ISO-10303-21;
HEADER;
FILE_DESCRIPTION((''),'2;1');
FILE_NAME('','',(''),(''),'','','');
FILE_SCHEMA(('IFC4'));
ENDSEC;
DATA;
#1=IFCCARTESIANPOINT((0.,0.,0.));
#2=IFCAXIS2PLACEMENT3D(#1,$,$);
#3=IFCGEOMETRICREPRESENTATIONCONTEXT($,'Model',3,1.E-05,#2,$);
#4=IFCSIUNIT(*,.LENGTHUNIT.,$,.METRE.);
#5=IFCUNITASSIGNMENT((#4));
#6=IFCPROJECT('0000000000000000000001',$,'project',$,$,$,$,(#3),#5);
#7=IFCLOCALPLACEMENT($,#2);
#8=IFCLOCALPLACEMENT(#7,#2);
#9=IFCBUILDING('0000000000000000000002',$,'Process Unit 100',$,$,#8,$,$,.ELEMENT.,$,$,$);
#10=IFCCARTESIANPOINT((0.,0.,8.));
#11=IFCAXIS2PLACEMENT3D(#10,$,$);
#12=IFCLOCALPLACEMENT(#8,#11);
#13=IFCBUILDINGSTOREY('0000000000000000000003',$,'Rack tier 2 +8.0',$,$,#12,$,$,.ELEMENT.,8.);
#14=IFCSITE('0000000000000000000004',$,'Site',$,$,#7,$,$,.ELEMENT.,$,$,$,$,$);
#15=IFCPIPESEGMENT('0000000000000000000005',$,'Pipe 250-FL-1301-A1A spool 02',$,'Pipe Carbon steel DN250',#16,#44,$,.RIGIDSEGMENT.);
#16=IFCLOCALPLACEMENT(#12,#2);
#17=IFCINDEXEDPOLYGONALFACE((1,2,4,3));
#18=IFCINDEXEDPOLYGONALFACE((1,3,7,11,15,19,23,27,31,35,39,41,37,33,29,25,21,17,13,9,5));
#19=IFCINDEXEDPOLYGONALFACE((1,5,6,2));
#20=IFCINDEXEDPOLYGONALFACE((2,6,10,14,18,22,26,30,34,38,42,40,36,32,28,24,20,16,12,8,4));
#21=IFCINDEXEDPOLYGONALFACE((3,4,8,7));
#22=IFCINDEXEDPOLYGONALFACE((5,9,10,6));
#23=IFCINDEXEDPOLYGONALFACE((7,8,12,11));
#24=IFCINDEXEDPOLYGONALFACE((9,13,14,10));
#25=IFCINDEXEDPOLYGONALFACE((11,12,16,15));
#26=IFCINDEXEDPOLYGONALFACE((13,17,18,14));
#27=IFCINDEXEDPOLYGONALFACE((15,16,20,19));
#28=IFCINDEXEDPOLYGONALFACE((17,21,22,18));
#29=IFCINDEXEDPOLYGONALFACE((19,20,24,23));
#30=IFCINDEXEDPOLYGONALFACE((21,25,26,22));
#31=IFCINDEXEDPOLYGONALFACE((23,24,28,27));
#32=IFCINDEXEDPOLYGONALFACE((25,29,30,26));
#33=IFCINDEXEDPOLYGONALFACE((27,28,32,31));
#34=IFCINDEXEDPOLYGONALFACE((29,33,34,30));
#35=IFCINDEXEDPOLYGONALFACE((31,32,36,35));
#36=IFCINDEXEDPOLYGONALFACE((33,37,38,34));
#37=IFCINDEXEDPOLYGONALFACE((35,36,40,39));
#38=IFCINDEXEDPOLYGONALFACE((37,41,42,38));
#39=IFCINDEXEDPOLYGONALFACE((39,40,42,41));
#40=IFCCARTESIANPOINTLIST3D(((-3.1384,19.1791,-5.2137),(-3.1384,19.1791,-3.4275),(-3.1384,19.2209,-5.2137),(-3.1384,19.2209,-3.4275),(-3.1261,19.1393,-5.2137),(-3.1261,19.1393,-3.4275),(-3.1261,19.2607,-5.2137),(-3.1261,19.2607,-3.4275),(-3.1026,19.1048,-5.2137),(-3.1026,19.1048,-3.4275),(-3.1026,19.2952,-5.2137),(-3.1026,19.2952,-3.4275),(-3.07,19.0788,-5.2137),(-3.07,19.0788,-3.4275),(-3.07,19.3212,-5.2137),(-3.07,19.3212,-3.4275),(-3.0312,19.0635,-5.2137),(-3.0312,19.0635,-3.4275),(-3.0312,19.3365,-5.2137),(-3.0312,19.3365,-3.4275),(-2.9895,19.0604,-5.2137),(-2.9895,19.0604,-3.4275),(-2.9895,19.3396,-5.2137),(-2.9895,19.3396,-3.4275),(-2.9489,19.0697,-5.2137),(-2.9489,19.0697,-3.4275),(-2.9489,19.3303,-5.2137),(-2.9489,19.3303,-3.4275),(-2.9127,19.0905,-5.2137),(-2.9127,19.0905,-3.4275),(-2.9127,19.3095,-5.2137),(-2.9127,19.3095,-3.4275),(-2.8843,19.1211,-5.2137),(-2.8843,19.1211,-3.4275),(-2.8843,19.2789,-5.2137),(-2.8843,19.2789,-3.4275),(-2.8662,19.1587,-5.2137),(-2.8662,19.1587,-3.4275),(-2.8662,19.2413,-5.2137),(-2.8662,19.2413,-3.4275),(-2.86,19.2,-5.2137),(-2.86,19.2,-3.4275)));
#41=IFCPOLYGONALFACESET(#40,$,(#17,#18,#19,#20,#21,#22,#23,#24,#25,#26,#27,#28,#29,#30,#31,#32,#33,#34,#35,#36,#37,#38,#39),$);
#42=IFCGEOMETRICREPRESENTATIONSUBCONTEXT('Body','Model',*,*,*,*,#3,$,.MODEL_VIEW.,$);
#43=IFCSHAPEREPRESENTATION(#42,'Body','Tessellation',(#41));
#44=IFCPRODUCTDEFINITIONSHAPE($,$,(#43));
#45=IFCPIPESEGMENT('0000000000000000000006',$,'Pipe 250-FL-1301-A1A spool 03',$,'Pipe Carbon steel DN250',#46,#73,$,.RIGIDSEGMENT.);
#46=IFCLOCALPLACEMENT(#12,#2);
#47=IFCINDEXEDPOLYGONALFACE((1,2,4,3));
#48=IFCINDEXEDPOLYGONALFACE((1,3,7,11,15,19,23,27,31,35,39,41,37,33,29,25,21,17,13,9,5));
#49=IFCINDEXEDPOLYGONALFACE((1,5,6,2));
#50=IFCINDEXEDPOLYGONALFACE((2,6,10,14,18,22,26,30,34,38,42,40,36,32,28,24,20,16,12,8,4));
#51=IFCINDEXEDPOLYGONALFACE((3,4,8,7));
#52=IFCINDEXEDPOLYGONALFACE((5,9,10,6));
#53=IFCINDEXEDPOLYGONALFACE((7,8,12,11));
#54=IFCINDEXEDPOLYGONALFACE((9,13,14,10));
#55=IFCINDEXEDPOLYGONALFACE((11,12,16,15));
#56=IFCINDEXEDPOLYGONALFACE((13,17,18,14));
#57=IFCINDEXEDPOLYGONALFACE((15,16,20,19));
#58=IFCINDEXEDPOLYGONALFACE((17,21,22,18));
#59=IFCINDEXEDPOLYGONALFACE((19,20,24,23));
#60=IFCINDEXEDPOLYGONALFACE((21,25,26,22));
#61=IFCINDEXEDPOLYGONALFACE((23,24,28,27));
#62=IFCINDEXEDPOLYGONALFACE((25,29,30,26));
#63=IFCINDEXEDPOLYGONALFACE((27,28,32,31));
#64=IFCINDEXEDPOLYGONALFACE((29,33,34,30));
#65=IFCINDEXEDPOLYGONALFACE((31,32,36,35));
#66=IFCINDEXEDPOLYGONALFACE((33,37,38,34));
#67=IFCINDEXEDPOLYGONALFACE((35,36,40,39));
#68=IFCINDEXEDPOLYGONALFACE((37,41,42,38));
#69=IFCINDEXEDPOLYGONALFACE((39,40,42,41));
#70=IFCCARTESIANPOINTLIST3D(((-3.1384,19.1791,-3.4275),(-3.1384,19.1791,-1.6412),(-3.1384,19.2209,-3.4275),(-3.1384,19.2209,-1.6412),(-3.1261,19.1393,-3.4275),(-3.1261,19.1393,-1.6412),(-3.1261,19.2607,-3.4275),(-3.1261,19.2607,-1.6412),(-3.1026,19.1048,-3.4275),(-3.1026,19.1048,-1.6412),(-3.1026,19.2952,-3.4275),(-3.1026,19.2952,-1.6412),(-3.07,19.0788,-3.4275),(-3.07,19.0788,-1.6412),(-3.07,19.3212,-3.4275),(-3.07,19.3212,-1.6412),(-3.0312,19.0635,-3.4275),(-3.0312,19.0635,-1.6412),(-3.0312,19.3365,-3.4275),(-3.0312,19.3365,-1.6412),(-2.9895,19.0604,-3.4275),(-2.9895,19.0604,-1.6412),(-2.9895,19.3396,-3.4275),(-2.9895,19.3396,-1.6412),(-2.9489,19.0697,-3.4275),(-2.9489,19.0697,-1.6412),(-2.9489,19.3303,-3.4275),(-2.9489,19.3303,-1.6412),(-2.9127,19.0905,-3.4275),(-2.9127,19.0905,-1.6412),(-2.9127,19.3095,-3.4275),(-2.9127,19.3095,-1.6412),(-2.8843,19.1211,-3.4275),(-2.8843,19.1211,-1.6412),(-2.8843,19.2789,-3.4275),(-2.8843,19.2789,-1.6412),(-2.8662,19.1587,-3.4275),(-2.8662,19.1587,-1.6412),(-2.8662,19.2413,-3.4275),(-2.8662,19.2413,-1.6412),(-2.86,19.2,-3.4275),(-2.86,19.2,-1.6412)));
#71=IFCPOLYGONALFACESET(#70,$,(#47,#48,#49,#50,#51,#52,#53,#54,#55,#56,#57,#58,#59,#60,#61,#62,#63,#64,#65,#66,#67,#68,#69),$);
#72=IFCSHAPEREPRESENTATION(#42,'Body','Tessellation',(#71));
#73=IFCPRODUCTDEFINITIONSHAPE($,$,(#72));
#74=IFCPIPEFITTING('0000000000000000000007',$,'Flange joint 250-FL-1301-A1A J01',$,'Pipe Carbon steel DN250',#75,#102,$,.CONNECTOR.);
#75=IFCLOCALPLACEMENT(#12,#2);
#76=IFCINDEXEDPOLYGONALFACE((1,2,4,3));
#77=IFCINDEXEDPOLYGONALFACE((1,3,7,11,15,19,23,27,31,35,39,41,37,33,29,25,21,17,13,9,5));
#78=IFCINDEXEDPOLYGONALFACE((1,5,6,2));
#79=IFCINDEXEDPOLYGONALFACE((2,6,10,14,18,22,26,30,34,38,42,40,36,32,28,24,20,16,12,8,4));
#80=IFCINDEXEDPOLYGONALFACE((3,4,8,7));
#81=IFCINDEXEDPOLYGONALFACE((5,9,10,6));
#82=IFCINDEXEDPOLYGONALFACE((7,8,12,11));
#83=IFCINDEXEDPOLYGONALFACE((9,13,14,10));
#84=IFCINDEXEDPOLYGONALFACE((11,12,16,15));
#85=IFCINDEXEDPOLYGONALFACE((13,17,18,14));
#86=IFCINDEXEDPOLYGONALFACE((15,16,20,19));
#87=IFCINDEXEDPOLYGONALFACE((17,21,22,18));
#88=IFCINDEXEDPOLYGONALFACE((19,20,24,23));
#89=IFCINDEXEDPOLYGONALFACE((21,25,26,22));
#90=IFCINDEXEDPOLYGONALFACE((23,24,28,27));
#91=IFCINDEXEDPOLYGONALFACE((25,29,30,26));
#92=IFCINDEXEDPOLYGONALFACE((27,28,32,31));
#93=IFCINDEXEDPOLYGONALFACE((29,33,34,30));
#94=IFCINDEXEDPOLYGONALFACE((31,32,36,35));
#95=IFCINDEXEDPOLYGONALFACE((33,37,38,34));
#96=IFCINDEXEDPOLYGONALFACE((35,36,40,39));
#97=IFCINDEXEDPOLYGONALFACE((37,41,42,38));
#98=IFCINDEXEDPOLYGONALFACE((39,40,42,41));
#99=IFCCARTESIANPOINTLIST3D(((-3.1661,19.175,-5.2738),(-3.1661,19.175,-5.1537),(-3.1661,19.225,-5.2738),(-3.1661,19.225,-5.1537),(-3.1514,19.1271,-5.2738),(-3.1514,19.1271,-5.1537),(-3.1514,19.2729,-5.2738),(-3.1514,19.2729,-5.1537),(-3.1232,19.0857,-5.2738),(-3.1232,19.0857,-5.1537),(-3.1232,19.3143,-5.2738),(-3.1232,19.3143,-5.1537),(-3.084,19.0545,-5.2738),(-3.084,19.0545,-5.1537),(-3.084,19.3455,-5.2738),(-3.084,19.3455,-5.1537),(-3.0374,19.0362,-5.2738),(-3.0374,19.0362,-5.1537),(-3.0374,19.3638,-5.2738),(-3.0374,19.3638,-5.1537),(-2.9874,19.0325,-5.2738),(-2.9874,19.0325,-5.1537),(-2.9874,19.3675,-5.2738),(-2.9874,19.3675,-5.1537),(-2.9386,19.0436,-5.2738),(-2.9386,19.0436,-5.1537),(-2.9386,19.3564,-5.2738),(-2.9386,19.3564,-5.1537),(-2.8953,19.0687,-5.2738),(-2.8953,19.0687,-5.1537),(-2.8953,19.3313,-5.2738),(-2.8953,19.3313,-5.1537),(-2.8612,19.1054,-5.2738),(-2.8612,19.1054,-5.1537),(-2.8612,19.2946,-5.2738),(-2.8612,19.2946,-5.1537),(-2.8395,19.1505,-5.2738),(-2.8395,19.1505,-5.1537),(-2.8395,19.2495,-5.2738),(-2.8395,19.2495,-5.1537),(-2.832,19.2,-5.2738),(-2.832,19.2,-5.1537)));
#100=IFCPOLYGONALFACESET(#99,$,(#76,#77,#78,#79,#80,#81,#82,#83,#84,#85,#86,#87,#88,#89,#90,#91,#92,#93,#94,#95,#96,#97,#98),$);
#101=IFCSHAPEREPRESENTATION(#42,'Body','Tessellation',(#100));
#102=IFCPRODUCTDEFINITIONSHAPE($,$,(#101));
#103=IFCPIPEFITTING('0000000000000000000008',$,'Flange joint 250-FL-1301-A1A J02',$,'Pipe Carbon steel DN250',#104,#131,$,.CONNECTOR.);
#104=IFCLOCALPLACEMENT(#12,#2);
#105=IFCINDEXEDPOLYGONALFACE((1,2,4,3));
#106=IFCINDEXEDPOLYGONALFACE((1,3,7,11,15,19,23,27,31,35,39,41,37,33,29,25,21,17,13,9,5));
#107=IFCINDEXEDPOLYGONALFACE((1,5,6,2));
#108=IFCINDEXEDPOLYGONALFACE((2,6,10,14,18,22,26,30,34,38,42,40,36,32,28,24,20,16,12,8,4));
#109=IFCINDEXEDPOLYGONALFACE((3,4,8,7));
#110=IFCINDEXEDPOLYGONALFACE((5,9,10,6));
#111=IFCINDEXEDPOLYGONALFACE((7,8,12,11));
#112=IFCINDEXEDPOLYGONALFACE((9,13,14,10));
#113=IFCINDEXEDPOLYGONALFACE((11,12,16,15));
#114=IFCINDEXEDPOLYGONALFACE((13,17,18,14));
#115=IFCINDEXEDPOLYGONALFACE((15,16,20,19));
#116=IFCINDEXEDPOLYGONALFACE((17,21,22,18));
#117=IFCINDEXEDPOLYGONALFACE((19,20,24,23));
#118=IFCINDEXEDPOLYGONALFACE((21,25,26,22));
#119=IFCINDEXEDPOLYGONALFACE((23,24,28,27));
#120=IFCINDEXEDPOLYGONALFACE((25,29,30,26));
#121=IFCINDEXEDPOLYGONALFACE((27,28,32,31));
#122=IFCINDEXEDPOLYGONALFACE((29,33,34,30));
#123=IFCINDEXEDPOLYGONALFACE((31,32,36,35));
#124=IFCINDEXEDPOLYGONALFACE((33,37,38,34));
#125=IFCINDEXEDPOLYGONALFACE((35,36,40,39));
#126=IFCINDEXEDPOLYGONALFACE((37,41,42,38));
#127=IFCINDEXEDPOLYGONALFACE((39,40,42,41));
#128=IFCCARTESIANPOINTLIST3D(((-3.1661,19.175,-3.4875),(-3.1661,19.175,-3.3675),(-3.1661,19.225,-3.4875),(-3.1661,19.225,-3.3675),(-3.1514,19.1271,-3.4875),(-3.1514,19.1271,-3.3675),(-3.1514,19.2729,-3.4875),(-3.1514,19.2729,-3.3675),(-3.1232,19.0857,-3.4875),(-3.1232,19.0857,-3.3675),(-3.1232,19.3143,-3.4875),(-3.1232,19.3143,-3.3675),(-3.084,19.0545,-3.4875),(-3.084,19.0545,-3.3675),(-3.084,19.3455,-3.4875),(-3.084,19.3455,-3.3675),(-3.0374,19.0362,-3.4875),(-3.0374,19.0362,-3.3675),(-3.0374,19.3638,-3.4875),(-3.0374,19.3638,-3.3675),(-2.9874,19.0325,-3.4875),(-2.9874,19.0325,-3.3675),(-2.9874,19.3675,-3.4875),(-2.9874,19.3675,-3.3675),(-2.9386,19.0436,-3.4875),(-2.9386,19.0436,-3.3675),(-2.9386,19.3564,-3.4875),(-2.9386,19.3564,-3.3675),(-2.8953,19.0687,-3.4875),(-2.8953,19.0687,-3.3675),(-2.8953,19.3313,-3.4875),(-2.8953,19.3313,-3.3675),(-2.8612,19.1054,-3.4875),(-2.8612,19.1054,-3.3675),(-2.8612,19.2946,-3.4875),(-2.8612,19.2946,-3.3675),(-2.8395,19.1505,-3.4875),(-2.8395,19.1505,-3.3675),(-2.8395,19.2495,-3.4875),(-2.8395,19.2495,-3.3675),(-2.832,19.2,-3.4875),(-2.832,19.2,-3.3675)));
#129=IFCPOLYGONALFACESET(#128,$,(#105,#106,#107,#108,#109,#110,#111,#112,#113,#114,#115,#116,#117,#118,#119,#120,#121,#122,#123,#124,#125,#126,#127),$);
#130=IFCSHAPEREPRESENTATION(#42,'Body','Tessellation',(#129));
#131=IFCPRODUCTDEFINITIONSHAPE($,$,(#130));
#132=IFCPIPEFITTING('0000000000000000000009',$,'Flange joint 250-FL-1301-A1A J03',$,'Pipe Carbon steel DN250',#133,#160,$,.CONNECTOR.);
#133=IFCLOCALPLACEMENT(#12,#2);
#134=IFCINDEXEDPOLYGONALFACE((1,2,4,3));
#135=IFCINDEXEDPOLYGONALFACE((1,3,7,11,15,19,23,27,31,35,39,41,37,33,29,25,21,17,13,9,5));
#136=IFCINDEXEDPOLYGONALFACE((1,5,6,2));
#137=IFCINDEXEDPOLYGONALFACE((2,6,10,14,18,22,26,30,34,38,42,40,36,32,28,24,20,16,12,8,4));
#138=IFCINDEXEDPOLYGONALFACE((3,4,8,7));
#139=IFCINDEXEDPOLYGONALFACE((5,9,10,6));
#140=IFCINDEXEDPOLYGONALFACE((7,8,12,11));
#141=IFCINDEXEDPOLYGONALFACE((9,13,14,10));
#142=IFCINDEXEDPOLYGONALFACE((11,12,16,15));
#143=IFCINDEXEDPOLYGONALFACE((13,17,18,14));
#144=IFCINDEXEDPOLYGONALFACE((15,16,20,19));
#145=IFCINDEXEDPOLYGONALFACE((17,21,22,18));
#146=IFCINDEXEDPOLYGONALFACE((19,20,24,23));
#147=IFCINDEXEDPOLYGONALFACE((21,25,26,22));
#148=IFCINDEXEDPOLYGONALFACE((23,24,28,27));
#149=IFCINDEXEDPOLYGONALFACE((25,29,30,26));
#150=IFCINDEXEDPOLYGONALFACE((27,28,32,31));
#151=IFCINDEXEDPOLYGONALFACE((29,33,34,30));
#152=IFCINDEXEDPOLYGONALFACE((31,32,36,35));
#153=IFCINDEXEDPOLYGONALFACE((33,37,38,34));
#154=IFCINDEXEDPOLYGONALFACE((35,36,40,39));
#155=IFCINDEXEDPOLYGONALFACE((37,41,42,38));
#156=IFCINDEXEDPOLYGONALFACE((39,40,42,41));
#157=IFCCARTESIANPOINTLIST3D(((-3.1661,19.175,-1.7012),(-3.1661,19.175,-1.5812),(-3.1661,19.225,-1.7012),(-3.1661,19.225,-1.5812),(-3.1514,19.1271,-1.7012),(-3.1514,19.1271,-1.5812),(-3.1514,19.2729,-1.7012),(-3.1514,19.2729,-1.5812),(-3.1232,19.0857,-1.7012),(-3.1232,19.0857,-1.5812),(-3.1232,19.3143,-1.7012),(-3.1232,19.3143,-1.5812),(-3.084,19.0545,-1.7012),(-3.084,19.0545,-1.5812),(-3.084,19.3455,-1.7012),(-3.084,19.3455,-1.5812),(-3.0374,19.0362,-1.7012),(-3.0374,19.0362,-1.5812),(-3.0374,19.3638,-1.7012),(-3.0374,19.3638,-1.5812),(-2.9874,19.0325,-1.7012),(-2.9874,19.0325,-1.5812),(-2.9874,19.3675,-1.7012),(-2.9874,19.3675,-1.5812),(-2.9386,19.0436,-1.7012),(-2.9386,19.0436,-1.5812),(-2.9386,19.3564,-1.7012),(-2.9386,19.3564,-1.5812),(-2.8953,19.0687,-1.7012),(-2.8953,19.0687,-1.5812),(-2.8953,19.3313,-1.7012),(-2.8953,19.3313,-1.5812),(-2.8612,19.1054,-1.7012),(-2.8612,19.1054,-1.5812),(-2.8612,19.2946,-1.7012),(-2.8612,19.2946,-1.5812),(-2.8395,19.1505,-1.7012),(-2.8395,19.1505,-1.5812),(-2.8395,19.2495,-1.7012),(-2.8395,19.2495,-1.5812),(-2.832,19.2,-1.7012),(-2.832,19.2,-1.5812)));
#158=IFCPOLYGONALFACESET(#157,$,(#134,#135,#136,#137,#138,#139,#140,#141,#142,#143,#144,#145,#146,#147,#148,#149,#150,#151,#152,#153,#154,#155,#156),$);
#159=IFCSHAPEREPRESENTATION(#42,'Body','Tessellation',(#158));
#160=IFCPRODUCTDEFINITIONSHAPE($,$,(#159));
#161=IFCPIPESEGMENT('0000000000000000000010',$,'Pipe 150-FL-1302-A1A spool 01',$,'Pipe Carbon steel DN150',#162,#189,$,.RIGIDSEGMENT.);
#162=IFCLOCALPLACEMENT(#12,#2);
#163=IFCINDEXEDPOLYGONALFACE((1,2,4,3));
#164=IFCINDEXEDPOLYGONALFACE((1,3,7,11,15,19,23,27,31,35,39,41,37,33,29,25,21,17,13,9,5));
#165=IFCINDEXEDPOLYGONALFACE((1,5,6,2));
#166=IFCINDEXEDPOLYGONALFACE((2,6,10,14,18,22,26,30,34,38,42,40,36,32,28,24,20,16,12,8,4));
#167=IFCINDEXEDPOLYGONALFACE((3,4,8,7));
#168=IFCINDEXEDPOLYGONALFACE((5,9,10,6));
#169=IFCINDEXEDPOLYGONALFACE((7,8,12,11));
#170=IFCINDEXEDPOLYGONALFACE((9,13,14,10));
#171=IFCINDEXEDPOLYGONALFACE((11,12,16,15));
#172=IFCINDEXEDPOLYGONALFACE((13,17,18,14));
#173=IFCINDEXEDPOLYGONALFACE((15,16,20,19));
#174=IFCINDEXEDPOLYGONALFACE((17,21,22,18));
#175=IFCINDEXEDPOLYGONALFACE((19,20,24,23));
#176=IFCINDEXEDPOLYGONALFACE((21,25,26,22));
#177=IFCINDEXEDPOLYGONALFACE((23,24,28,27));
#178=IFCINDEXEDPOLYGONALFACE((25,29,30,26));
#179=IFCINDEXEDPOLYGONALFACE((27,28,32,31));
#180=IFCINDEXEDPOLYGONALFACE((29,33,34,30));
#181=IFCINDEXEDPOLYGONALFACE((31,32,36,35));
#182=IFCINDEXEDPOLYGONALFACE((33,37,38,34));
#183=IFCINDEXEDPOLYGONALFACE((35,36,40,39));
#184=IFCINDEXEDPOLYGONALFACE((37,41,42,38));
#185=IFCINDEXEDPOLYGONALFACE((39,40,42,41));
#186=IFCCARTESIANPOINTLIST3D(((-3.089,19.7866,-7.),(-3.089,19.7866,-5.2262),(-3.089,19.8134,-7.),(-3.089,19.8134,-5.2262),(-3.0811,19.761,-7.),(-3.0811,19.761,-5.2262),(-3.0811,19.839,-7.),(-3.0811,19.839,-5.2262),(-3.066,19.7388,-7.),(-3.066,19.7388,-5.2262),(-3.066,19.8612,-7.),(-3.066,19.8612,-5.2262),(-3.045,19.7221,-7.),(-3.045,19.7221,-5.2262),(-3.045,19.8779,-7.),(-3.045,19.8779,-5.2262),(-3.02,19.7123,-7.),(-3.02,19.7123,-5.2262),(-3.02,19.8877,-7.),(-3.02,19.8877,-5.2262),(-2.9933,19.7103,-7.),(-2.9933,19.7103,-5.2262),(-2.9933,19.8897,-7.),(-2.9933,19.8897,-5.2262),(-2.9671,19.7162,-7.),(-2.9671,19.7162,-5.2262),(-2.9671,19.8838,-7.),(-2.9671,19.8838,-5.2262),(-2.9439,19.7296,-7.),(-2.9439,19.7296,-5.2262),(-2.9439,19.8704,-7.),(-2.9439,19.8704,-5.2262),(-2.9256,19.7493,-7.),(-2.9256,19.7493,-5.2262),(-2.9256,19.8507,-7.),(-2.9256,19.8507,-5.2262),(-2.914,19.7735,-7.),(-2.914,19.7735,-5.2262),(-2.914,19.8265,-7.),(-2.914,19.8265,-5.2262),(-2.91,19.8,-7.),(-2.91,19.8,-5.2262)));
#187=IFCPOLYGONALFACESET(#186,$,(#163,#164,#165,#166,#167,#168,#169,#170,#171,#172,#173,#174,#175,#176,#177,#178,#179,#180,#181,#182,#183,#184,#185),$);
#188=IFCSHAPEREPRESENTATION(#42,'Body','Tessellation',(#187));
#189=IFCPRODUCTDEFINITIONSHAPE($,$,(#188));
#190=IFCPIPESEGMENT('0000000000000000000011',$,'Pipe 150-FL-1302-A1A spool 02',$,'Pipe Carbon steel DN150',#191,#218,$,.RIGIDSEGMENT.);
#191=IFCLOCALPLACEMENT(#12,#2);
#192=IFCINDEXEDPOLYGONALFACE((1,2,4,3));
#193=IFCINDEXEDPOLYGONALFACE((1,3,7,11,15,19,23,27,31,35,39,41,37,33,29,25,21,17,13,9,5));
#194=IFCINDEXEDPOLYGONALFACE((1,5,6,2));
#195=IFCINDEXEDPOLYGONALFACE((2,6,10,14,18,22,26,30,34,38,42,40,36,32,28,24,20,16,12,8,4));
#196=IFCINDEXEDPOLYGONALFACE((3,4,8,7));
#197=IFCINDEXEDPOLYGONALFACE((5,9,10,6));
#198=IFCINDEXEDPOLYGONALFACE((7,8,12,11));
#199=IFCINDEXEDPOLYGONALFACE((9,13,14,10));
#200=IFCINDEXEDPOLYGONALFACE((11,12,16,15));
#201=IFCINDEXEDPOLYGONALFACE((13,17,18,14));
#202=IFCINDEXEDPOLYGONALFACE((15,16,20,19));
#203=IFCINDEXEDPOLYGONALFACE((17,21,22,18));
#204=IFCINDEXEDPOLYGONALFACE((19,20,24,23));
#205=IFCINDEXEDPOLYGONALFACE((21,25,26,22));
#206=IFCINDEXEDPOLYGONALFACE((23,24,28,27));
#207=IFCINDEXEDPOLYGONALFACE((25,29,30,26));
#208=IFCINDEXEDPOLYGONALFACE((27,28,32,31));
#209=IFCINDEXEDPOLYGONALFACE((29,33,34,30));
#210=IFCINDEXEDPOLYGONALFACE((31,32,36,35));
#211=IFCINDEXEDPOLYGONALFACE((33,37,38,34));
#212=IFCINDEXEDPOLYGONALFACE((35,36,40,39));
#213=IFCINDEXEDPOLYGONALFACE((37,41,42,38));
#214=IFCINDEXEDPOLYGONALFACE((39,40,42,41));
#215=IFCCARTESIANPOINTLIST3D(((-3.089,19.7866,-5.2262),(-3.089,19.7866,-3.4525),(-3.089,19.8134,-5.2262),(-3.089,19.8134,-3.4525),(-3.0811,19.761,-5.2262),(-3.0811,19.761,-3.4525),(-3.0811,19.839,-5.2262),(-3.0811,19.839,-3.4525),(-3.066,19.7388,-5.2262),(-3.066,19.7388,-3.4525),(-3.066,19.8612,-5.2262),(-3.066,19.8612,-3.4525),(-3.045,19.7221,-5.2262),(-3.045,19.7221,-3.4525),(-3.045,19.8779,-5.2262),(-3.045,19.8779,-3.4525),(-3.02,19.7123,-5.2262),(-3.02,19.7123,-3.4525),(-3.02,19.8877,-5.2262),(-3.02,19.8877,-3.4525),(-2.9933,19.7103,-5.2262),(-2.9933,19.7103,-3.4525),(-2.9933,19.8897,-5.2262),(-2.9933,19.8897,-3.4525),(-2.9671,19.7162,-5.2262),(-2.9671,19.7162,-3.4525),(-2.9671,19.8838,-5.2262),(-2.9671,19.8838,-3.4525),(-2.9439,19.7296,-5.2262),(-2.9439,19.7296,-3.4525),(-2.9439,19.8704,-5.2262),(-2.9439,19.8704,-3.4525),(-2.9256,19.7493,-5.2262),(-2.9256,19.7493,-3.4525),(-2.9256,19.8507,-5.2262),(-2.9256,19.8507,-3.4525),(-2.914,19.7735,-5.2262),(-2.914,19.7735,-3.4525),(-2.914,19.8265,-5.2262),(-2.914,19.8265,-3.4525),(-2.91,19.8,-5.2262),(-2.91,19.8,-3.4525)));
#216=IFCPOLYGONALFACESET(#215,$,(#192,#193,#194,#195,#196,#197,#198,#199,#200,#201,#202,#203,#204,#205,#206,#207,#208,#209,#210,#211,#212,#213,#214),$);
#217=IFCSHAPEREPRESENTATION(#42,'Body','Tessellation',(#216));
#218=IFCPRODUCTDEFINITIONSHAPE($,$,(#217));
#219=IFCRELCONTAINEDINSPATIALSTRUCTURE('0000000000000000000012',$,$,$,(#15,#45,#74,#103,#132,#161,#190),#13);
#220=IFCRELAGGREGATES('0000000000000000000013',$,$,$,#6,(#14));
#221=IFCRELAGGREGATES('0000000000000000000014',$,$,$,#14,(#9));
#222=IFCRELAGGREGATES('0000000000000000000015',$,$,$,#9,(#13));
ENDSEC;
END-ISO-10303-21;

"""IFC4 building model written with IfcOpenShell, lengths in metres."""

from ifc_helpers import new_model, si_unit, frame, origin, place, context, subcontext, project, spatial, circle, extrude, element, save


model = new_model("IFC4")

# Units and contexts
model_context = context("Model", 3, precision=1e-05, world=origin())
body_context = subcontext(model_context, "Body", "Model", "MODEL_VIEW")
ifc_project = project(units=[si_unit("LENGTHUNIT", "METRE")], contexts=[model_context])

# Site, building, storey
site_placement = place(None, origin())
site = spatial("IfcSite", under=ifc_project, at=site_placement, Name="Site", CompositionType="ELEMENT")
building_placement = place(site_placement, origin())
building = spatial("IfcBuilding", under=site, at=building_placement, Name="Process Unit 100", CompositionType="ELEMENT")
storey_placement = place(building_placement, frame((0.0, 0.0, 8.0)))
storey = spatial("IfcBuildingStorey", under=building, at=storey_placement, Name="Rack tier 2 +8.0", CompositionType="ELEMENT", Elevation=8.0)

# Pipe segments
for number, where, z_axis, x_axis, name in (
    (1, (-3.0, 19.2, -5.2137), (0.0, 0.0, 1.0), (1.0, 0.0, 0.0), "Pipe 250-FL-1301-A1A spool 02"),
    (2, (-3.0, 19.2, -3.4275), (0.0, 0.0, 1.0), (1.0, 0.0, 0.0), "Pipe 250-FL-1301-A1A spool 03"),
):
    element("IfcPipeSegment", number, at=place(storey_placement, frame(where, z_axis=z_axis, x_axis=x_axis)), inside=storey, Name=name, ObjectType="Pipe Carbon steel DN250", PredefinedType="RIGIDSEGMENT", context=body_context, shape_type="SweptSolid", body=[
        extrude(circle(Radius=0.14), origin(), (0.0, 0.0, 1.0), 1.7863),
    ])

# Pipe fittings
for number, where, z_axis, x_axis, name in (
    (3, (-3.0, 19.2, -5.2737), (0.0, 0.0, 1.0), (1.0, 0.0, 0.0), "Flange joint 250-FL-1301-A1A J01"),
    (4, (-3.0, 19.2, -3.4875), (0.0, 0.0, 1.0), (1.0, 0.0, 0.0), "Flange joint 250-FL-1301-A1A J02"),
    (5, (-3.0, 19.2, -1.7012), (0.0, 0.0, 1.0), (1.0, 0.0, 0.0), "Flange joint 250-FL-1301-A1A J03"),
):
    element("IfcPipeFitting", number, at=place(storey_placement, frame(where, z_axis=z_axis, x_axis=x_axis)), inside=storey, Name=name, ObjectType="Pipe Carbon steel DN250", PredefinedType="CONNECTOR", context=body_context, shape_type="SweptSolid", body=[
        extrude(circle(Radius=0.168), origin(), (0.0, 0.0, 1.0), 0.12),
    ])

# Pipe segments
for number, where, z_axis, x_axis, name in (
    (6, (-3.0, 19.8, -7.0), (0.0, 0.0, 1.0), (1.0, 0.0, 0.0), "Pipe 150-FL-1302-A1A spool 01"),
    (7, (-3.0, 19.8, -5.2263), (0.0, 0.0, 1.0), (1.0, 0.0, 0.0), "Pipe 150-FL-1302-A1A spool 02"),
):
    element("IfcPipeSegment", number, at=place(storey_placement, frame(where, z_axis=z_axis, x_axis=x_axis)), inside=storey, Name=name, ObjectType="Pipe Carbon steel DN150", PredefinedType="RIGIDSEGMENT", context=body_context, shape_type="SweptSolid", body=[
        extrude(circle(Radius=0.09), origin(), (0.0, 0.0, 1.0), 1.7738),
    ])

save(model, "model.ifc")
